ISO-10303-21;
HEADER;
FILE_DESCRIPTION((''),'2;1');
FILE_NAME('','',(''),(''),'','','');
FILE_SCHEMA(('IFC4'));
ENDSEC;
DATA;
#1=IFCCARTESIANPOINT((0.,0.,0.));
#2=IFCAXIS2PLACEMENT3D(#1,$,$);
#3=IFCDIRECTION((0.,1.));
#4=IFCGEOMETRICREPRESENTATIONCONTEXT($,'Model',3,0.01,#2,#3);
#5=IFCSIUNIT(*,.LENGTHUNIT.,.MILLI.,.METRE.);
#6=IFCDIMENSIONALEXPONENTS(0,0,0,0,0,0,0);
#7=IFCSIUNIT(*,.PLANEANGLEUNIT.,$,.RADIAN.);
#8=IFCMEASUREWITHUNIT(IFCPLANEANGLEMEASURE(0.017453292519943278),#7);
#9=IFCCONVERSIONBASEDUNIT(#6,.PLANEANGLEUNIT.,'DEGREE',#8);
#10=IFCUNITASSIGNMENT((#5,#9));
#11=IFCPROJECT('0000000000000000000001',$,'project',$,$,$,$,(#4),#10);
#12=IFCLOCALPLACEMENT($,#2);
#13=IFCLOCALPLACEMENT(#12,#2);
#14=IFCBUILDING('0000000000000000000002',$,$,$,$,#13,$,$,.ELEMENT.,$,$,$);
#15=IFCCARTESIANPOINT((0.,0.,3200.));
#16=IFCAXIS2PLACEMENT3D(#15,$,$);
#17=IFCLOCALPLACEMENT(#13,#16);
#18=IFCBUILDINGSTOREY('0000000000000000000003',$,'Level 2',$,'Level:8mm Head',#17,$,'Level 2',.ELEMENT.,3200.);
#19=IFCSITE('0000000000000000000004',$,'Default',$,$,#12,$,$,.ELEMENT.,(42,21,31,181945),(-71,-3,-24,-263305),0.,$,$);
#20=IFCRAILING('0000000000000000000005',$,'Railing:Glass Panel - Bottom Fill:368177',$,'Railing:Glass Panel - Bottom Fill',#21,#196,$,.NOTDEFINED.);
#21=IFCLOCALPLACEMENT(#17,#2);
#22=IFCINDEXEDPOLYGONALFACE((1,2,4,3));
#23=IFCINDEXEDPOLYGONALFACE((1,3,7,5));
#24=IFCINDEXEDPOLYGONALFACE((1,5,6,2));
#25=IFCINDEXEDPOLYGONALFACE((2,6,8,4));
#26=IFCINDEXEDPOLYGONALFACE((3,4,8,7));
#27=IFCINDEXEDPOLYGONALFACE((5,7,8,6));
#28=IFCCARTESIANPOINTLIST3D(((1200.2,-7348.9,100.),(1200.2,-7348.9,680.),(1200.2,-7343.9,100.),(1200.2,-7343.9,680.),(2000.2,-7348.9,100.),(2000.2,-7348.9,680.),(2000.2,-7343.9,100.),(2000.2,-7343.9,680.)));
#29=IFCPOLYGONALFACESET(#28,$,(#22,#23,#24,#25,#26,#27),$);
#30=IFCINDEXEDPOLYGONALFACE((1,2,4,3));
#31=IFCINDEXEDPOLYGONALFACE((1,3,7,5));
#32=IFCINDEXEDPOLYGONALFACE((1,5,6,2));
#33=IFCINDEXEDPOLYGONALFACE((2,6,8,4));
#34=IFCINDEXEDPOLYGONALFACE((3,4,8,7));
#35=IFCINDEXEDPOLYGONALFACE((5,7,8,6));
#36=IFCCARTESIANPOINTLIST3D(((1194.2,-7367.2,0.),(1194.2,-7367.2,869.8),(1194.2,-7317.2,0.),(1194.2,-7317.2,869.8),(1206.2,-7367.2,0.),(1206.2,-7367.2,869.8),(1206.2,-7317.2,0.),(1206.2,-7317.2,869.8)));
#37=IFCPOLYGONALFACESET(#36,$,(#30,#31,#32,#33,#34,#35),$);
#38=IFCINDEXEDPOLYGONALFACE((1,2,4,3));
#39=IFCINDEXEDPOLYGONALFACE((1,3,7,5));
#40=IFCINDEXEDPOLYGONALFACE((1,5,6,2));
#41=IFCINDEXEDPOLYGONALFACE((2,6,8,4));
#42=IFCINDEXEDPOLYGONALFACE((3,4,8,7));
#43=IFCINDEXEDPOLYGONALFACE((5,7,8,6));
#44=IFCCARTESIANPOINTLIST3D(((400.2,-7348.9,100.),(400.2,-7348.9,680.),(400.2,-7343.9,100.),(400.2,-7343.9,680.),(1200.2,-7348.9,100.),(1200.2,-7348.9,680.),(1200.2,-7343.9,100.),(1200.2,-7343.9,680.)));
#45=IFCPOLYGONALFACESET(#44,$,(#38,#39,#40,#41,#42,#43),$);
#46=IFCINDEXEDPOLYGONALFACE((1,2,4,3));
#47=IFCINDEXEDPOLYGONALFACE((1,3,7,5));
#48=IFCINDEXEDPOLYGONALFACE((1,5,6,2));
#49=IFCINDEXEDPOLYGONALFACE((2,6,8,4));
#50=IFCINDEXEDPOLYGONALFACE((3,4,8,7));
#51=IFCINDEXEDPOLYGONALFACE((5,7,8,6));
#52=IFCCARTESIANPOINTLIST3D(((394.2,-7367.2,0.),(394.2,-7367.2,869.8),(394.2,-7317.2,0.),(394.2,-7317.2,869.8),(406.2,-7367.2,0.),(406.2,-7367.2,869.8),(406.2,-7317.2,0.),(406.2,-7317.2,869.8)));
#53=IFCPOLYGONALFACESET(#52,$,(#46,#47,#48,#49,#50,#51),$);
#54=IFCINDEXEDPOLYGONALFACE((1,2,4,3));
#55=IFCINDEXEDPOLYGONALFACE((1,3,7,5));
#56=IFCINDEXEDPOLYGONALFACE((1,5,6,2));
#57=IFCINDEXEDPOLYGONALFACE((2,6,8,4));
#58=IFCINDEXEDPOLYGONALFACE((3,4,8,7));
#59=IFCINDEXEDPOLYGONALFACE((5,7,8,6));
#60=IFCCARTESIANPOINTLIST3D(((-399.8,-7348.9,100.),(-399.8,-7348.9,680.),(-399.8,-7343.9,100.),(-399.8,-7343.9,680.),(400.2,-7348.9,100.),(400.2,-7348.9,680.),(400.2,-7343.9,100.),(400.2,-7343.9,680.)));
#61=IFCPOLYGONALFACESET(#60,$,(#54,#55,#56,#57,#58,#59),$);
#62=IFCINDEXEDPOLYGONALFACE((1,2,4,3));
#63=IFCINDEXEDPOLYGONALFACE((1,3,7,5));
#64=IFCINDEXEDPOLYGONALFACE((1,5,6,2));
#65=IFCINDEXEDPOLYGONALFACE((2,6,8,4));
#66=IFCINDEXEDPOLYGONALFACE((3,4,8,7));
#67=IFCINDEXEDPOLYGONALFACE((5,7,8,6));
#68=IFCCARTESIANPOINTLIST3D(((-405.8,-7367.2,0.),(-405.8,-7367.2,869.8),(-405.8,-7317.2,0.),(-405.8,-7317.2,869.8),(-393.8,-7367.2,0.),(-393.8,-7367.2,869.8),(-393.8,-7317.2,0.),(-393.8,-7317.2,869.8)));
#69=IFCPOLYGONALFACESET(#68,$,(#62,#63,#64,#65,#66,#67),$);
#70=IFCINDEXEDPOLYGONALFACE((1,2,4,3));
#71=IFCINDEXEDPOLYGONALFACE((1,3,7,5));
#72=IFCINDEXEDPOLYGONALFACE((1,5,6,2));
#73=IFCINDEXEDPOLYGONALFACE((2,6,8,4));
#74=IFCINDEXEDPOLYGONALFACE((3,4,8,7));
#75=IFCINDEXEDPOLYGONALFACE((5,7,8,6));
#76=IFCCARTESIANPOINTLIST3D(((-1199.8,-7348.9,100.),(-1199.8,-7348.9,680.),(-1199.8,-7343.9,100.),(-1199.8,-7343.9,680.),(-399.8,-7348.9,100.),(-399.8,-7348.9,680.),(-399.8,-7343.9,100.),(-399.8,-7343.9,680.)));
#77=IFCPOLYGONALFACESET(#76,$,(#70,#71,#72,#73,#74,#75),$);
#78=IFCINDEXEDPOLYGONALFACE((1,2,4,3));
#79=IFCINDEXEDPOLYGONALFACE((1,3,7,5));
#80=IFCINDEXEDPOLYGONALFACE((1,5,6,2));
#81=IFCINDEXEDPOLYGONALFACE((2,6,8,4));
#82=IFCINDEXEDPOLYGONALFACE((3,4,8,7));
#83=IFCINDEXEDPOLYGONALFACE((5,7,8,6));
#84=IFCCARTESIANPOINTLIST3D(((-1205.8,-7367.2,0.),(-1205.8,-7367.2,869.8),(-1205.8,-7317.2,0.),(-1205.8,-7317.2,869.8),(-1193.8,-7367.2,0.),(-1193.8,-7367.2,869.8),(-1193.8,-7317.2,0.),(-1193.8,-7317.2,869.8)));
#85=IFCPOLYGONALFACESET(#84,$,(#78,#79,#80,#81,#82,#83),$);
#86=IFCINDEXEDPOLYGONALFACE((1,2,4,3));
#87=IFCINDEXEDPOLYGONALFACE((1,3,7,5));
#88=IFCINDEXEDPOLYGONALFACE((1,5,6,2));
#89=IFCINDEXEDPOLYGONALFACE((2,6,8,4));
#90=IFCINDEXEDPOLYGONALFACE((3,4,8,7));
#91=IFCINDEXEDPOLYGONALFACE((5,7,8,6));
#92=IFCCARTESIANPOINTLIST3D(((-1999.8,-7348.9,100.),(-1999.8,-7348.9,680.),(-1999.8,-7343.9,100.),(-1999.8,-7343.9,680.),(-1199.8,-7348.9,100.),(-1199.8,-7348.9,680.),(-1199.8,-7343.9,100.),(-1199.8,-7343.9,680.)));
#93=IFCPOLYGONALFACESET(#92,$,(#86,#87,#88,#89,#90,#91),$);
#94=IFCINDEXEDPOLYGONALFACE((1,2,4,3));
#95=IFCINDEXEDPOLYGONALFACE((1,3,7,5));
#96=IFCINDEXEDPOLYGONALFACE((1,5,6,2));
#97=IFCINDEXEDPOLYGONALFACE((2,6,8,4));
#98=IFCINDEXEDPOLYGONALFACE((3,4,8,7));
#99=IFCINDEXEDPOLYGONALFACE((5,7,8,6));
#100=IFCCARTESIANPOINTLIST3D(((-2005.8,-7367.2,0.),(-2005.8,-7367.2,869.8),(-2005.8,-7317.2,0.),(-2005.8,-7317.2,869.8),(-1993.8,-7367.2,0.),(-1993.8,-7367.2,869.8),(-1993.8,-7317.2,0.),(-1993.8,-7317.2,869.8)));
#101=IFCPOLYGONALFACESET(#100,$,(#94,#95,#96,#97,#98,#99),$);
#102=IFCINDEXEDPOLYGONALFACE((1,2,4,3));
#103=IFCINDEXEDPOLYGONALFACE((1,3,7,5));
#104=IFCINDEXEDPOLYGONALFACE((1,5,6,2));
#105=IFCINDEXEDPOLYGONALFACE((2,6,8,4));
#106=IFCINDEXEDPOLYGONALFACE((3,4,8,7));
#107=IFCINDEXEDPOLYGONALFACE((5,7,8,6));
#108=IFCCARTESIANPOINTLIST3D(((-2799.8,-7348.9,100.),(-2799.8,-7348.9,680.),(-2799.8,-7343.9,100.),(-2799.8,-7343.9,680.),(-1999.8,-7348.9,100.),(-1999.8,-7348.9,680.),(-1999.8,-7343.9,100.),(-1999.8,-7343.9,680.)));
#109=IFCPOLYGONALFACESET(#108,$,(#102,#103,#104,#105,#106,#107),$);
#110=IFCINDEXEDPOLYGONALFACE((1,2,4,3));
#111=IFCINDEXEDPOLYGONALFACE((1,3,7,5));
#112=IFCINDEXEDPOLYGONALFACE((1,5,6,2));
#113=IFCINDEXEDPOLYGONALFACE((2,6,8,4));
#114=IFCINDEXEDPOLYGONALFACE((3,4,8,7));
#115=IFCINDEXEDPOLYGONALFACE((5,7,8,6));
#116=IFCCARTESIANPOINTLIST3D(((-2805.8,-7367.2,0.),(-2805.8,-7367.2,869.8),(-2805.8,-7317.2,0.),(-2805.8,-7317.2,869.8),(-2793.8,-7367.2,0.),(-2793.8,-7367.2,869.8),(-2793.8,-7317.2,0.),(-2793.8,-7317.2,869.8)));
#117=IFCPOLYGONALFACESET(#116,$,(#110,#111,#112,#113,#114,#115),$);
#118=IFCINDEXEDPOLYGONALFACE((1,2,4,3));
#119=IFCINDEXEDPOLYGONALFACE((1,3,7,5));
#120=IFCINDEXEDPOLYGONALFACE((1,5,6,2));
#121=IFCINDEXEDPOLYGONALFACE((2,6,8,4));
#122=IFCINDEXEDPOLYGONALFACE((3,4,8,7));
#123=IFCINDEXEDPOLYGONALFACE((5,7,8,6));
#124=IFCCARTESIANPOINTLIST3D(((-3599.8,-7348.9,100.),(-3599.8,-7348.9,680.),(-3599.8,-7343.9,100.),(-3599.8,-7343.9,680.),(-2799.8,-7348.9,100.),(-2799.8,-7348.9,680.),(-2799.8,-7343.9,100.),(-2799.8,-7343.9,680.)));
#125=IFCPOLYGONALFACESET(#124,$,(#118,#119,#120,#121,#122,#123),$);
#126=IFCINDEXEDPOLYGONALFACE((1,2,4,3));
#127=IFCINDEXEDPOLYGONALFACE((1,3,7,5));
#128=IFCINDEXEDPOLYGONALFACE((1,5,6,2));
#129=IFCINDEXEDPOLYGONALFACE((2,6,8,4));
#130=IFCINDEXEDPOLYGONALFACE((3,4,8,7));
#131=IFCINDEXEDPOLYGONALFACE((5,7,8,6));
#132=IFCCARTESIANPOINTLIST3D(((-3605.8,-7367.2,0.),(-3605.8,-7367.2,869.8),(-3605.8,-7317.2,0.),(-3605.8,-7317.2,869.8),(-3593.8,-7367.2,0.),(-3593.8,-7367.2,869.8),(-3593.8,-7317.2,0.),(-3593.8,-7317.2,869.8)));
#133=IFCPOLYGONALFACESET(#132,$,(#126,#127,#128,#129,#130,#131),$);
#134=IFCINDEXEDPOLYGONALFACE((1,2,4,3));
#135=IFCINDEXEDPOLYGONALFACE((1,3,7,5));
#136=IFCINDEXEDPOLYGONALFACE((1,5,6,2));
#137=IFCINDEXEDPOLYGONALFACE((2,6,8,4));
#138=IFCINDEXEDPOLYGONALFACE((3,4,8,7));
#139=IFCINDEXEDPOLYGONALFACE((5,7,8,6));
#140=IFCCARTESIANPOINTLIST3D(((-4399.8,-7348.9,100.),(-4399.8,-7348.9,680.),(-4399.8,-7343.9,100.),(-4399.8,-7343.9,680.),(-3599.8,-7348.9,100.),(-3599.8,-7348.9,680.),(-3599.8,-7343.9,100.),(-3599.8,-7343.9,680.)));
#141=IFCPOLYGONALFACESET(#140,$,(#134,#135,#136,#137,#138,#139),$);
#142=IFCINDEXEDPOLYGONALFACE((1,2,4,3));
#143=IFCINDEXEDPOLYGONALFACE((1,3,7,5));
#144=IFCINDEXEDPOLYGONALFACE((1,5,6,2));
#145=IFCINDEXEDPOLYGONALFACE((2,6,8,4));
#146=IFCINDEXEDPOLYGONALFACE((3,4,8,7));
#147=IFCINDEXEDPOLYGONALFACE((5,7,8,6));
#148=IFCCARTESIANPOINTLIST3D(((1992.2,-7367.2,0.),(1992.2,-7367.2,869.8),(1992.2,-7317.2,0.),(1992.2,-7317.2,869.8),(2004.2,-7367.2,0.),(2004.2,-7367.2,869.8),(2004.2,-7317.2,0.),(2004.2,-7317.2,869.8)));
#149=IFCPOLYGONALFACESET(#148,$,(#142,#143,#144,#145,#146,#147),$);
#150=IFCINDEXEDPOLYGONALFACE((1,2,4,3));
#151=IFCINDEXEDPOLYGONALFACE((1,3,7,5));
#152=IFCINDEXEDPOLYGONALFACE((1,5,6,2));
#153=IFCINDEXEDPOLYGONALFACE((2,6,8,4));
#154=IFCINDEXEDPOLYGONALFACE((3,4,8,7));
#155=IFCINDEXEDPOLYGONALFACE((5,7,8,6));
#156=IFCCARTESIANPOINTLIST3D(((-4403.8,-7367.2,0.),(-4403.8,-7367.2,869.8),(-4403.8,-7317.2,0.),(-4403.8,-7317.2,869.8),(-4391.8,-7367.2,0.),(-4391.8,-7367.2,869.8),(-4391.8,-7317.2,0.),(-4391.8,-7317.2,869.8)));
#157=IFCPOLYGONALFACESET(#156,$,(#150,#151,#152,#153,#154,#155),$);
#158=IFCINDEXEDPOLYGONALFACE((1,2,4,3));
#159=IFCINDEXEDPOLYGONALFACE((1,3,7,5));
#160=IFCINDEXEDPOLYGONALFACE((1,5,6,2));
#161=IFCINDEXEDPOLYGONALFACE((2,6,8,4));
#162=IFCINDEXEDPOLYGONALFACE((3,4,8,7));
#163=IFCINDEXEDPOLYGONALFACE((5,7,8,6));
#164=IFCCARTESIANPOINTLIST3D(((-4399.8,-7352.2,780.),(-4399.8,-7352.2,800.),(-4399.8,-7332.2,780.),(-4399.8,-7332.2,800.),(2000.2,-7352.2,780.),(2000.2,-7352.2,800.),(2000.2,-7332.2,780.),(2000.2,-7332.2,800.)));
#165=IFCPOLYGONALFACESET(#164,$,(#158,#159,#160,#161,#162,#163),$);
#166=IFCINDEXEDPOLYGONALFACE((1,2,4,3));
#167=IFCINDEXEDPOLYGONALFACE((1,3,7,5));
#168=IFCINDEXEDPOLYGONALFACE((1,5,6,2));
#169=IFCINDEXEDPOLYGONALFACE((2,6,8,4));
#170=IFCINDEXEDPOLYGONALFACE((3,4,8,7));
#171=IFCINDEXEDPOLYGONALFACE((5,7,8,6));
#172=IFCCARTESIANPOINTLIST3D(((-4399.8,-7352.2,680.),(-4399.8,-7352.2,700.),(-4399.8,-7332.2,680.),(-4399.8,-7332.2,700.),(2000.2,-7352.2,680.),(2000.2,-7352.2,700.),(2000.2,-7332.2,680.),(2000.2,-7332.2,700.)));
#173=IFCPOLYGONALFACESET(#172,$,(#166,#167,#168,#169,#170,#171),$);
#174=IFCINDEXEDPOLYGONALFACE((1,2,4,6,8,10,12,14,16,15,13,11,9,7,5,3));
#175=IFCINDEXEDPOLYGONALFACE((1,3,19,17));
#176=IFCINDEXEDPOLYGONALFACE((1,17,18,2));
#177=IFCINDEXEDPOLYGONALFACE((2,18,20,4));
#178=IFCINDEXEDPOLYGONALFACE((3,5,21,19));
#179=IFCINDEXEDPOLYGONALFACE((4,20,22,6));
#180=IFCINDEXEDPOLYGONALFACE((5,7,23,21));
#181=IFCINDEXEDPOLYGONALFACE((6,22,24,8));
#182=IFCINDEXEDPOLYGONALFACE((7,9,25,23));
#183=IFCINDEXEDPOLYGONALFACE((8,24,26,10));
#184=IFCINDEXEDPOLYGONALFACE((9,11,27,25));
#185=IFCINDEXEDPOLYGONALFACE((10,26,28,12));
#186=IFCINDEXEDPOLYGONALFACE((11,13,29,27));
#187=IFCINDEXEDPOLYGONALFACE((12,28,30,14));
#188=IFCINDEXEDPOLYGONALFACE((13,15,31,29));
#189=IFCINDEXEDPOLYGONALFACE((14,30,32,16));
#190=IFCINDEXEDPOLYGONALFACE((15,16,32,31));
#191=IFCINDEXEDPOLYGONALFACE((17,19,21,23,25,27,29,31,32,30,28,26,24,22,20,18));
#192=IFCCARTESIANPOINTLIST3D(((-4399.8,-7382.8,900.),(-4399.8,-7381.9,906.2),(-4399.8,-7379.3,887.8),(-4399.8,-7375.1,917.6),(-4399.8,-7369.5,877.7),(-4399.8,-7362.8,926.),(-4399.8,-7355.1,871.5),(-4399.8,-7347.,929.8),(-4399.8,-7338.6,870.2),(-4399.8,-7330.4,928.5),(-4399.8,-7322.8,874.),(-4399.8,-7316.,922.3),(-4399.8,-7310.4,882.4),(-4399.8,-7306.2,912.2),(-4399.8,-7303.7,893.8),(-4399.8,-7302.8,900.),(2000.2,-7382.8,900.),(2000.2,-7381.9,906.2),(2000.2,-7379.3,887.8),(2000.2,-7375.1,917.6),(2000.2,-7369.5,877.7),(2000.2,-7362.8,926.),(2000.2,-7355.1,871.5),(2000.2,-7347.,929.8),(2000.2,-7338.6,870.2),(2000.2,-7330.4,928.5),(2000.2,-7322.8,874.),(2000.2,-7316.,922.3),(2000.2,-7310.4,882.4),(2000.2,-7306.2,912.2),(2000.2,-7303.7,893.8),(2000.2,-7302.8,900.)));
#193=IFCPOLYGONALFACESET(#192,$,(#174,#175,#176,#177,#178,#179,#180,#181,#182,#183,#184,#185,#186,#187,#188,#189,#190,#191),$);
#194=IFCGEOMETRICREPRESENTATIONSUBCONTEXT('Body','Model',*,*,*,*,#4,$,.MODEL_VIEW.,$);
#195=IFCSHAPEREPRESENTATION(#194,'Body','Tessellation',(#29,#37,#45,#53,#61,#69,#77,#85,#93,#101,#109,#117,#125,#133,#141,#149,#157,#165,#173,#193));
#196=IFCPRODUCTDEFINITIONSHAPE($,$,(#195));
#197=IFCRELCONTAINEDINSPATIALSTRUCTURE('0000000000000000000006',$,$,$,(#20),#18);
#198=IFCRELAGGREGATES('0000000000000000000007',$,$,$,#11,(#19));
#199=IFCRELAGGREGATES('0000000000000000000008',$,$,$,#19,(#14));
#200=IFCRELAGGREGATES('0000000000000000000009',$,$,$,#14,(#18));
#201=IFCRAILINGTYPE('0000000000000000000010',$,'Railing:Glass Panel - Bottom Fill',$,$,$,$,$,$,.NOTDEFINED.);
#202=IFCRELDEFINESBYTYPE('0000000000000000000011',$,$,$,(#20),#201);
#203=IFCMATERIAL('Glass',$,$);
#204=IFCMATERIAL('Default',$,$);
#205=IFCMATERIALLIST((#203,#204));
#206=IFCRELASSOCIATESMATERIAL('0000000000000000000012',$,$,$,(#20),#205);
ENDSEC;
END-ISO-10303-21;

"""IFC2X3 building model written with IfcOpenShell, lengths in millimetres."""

from ifc_helpers import new_model, entity, si_unit, converted_unit, direction, frame, frame_2d, origin, origin_2d_with_axis, place, context, subcontext, project, spatial, polyline, rectangle, outline, extrude, material, material_list, type_object, element, save


model = new_model("IFC2X3")

# Units and contexts
model_context = context("Model", 3, precision=0.01, world=origin(), true_north=direction((0.0, 1.0)))
body_context = subcontext(model_context, "Body", "Model", "MODEL_VIEW")
ifc_project = project(units=[si_unit("LENGTHUNIT", "METRE", prefix="MILLI"), converted_unit("PLANEANGLEUNIT", "DEGREE", entity("IfcPlaneAngleMeasure", 0.017453292519943278), si_unit("PLANEANGLEUNIT", "RADIAN"), dimensions=[0, 0, 0, 0, 0, 0, 0])], contexts=[model_context])

# Site, building, storey
site_placement = place(None, origin())
site = spatial("IfcSite", under=ifc_project, at=site_placement, Name="Default", CompositionType="ELEMENT", RefLatitude=(42, 21, 31, 181945), RefLongitude=(-71, -3, -24, -263305), RefElevation=0.0)
building_placement = place(site_placement, origin())
building = spatial("IfcBuilding", under=site, at=building_placement, CompositionType="ELEMENT")
storey_placement = place(building_placement, frame((0.0, 0.0, 3200.0)))
storey = spatial("IfcBuildingStorey", under=building, at=storey_placement, Name="Level 2", ObjectType="Level:8mm Head", LongName="Level 2", CompositionType="ELEMENT", Elevation=3200.0)

# Shared definitions
ifc_material_1 = material(Name="Glass")

# Shared definitions
ifc_material_2 = material(Name="Default")

# Railing
ifc_material_list = material_list([ifc_material_1, ifc_material_2])
railing_type = type_object("IfcRailingType", Name="Railing:Glass Panel - Bottom Fill", PredefinedType="NOTDEFINED")
railing_placement = place(storey_placement, origin())
element("IfcRailing", 1, at=railing_placement, inside=storey, type_object=railing_type, material=ifc_material_list, Name="Railing:Glass Panel - Bottom Fill:368177", ObjectType="Railing:Glass Panel - Bottom Fill", PredefinedType="NOTDEFINED", context=body_context, shape_type="SweptSolid", body=[
    extrude(rectangle(XDim=5.0, YDim=800.0, at=frame_2d((0.0, 0.0), x_axis=(1.0, 0.0))), frame((1600.2, -7346.4, 100.0), z_axis=(0.0, 0.0, 1.0), x_axis=(0.0, -1.0, 0.0)), (0.0, 0.0, 1.0), 580.0),
    extrude(rectangle(XDim=50.0, YDim=12.0, at=origin_2d_with_axis()), frame((1200.2, -7342.2, 0.0), z_axis=(0.0, 0.0, 1.0), x_axis=(0.0, -1.0, 0.0)), (0.0, 0.0, 1.0), 869.8),
    extrude(rectangle(XDim=5.0, YDim=800.0, at=frame_2d((0.0, 0.0), x_axis=(1.0, 0.0))), frame((800.2, -7346.4, 100.0), z_axis=(0.0, 0.0, 1.0), x_axis=(0.0, -1.0, 0.0)), (0.0, 0.0, 1.0), 580.0),
    extrude(rectangle(XDim=50.0, YDim=12.0, at=frame_2d((0.0, 0.0), x_axis=(1.0, 0.0))), frame((400.2, -7342.2, 0.0), z_axis=(0.0, 0.0, 1.0), x_axis=(0.0, -1.0, 0.0)), (0.0, 0.0, 1.0), 869.8),
    extrude(rectangle(XDim=5.0, YDim=800.0, at=frame_2d((0.0, 0.0), x_axis=(1.0, 0.0))), frame((0.2, -7346.4, 100.0), z_axis=(0.0, 0.0, 1.0), x_axis=(0.0, -1.0, 0.0)), (0.0, 0.0, 1.0), 580.0),
    extrude(rectangle(XDim=50.0, YDim=12.0, at=frame_2d((0.0, 0.0), x_axis=(1.0, 0.0))), frame((-399.8, -7342.2, 0.0), z_axis=(0.0, 0.0, 1.0), x_axis=(0.0, -1.0, 0.0)), (0.0, 0.0, 1.0), 869.8),
    extrude(rectangle(XDim=5.0, YDim=800.0, at=frame_2d((0.0, 0.0), x_axis=(1.0, 0.0))), frame((-799.8, -7346.4, 100.0), z_axis=(0.0, 0.0, 1.0), x_axis=(0.0, -1.0, 0.0)), (0.0, 0.0, 1.0), 580.0),
    extrude(rectangle(XDim=50.0, YDim=12.0, at=origin_2d_with_axis()), frame((-1199.8, -7342.2, 0.0), z_axis=(0.0, 0.0, 1.0), x_axis=(0.0, -1.0, 0.0)), (0.0, 0.0, 1.0), 869.8),
    extrude(rectangle(XDim=5.0, YDim=800.0, at=frame_2d((0.0, 0.0), x_axis=(1.0, 0.0))), frame((-1599.8, -7346.4, 100.0), z_axis=(0.0, 0.0, 1.0), x_axis=(0.0, -1.0, 0.0)), (0.0, 0.0, 1.0), 580.0),
    extrude(rectangle(XDim=50.0, YDim=12.0, at=frame_2d((0.0, 0.0), x_axis=(1.0, 0.0))), frame((-1999.8, -7342.2, 0.0), z_axis=(0.0, 0.0, 1.0), x_axis=(0.0, -1.0, 0.0)), (0.0, 0.0, 1.0), 869.8),
    extrude(rectangle(XDim=5.0, YDim=800.0, at=frame_2d((0.0, 0.0), x_axis=(1.0, 0.0))), frame((-2399.8, -7346.4, 100.0), z_axis=(0.0, 0.0, 1.0), x_axis=(0.0, -1.0, 0.0)), (0.0, 0.0, 1.0), 580.0),
    extrude(rectangle(XDim=50.0, YDim=12.0, at=frame_2d((0.0, 0.0), x_axis=(1.0, 0.0))), frame((-2799.8, -7342.2, 0.0), z_axis=(0.0, 0.0, 1.0), x_axis=(0.0, -1.0, 0.0)), (0.0, 0.0, 1.0), 869.8),
    extrude(rectangle(XDim=5.0, YDim=800.0, at=frame_2d((0.0, 0.0), x_axis=(1.0, 0.0))), frame((-3199.8, -7346.4, 100.0), z_axis=(0.0, 0.0, 1.0), x_axis=(0.0, -1.0, 0.0)), (0.0, 0.0, 1.0), 580.0),
    extrude(rectangle(XDim=50.0, YDim=12.0, at=frame_2d((0.0, 0.0), x_axis=(1.0, 0.0))), frame((-3599.8, -7342.2, 0.0), z_axis=(0.0, 0.0, 1.0), x_axis=(0.0, -1.0, 0.0)), (0.0, 0.0, 1.0), 869.8),
    extrude(rectangle(XDim=5.0, YDim=800.0, at=frame_2d((0.0, 0.0), x_axis=(1.0, 0.0))), frame((-3999.8, -7346.4, 100.0), z_axis=(0.0, 0.0, 1.0), x_axis=(0.0, -1.0, 0.0)), (0.0, 0.0, 1.0), 580.0),
    extrude(rectangle(XDim=50.0, YDim=12.0, at=frame_2d((0.0, 0.0), x_axis=(1.0, 0.0))), frame((1998.2, -7342.2, 0.0), z_axis=(0.0, 0.0, 1.0), x_axis=(0.0, -1.0, 0.0)), (0.0, 0.0, 1.0), 869.8),
    extrude(rectangle(XDim=50.0, YDim=12.0, at=frame_2d((0.0, 0.0), x_axis=(1.0, 0.0))), frame((-4397.8, -7342.2, 0.0), z_axis=(0.0, 0.0, 1.0), x_axis=(0.0, -1.0, 0.0)), (0.0, 0.0, 1.0), 869.8),
    extrude(rectangle(XDim=6400.0, YDim=20.0, at=frame_2d((0.0, 0.0), x_axis=(1.0, 0.0))), frame((-1199.8, -7342.2, 780.0)), (0.0, 0.0, 1.0), 20.0),
    extrude(rectangle(XDim=6400.0, YDim=20.0, at=frame_2d((0.0, 0.0), x_axis=(1.0, 0.0))), frame((-1199.8, -7342.2, 680.0)), (0.0, 0.0, 1.0), 20.0),
    extrude(outline(polyline([(-10.9, -38.5), (1.8, -38.5), (14.2, -31.8), (24.1, -19.7), (29.8, -4.1), (30.4, 12.2), (25.8, 26.3), (16.7, 35.9), (10.9, 38.5), (-1.8, 38.5), (-14.2, 31.8), (-24.1, 19.7), (-29.8, 4.1), (-30.4, -12.2), (-25.8, -26.3), (-16.7, -35.9), (-10.9, -38.5)])), frame((-4399.8, -7342.8, 900.0), z_axis=(1.0, 0.0, 0.0), x_axis=(0.0, -0.27267, 0.962108)), (0.0, 0.0, 1.0), 6400.0),
])

save(model, "model.ifc")
